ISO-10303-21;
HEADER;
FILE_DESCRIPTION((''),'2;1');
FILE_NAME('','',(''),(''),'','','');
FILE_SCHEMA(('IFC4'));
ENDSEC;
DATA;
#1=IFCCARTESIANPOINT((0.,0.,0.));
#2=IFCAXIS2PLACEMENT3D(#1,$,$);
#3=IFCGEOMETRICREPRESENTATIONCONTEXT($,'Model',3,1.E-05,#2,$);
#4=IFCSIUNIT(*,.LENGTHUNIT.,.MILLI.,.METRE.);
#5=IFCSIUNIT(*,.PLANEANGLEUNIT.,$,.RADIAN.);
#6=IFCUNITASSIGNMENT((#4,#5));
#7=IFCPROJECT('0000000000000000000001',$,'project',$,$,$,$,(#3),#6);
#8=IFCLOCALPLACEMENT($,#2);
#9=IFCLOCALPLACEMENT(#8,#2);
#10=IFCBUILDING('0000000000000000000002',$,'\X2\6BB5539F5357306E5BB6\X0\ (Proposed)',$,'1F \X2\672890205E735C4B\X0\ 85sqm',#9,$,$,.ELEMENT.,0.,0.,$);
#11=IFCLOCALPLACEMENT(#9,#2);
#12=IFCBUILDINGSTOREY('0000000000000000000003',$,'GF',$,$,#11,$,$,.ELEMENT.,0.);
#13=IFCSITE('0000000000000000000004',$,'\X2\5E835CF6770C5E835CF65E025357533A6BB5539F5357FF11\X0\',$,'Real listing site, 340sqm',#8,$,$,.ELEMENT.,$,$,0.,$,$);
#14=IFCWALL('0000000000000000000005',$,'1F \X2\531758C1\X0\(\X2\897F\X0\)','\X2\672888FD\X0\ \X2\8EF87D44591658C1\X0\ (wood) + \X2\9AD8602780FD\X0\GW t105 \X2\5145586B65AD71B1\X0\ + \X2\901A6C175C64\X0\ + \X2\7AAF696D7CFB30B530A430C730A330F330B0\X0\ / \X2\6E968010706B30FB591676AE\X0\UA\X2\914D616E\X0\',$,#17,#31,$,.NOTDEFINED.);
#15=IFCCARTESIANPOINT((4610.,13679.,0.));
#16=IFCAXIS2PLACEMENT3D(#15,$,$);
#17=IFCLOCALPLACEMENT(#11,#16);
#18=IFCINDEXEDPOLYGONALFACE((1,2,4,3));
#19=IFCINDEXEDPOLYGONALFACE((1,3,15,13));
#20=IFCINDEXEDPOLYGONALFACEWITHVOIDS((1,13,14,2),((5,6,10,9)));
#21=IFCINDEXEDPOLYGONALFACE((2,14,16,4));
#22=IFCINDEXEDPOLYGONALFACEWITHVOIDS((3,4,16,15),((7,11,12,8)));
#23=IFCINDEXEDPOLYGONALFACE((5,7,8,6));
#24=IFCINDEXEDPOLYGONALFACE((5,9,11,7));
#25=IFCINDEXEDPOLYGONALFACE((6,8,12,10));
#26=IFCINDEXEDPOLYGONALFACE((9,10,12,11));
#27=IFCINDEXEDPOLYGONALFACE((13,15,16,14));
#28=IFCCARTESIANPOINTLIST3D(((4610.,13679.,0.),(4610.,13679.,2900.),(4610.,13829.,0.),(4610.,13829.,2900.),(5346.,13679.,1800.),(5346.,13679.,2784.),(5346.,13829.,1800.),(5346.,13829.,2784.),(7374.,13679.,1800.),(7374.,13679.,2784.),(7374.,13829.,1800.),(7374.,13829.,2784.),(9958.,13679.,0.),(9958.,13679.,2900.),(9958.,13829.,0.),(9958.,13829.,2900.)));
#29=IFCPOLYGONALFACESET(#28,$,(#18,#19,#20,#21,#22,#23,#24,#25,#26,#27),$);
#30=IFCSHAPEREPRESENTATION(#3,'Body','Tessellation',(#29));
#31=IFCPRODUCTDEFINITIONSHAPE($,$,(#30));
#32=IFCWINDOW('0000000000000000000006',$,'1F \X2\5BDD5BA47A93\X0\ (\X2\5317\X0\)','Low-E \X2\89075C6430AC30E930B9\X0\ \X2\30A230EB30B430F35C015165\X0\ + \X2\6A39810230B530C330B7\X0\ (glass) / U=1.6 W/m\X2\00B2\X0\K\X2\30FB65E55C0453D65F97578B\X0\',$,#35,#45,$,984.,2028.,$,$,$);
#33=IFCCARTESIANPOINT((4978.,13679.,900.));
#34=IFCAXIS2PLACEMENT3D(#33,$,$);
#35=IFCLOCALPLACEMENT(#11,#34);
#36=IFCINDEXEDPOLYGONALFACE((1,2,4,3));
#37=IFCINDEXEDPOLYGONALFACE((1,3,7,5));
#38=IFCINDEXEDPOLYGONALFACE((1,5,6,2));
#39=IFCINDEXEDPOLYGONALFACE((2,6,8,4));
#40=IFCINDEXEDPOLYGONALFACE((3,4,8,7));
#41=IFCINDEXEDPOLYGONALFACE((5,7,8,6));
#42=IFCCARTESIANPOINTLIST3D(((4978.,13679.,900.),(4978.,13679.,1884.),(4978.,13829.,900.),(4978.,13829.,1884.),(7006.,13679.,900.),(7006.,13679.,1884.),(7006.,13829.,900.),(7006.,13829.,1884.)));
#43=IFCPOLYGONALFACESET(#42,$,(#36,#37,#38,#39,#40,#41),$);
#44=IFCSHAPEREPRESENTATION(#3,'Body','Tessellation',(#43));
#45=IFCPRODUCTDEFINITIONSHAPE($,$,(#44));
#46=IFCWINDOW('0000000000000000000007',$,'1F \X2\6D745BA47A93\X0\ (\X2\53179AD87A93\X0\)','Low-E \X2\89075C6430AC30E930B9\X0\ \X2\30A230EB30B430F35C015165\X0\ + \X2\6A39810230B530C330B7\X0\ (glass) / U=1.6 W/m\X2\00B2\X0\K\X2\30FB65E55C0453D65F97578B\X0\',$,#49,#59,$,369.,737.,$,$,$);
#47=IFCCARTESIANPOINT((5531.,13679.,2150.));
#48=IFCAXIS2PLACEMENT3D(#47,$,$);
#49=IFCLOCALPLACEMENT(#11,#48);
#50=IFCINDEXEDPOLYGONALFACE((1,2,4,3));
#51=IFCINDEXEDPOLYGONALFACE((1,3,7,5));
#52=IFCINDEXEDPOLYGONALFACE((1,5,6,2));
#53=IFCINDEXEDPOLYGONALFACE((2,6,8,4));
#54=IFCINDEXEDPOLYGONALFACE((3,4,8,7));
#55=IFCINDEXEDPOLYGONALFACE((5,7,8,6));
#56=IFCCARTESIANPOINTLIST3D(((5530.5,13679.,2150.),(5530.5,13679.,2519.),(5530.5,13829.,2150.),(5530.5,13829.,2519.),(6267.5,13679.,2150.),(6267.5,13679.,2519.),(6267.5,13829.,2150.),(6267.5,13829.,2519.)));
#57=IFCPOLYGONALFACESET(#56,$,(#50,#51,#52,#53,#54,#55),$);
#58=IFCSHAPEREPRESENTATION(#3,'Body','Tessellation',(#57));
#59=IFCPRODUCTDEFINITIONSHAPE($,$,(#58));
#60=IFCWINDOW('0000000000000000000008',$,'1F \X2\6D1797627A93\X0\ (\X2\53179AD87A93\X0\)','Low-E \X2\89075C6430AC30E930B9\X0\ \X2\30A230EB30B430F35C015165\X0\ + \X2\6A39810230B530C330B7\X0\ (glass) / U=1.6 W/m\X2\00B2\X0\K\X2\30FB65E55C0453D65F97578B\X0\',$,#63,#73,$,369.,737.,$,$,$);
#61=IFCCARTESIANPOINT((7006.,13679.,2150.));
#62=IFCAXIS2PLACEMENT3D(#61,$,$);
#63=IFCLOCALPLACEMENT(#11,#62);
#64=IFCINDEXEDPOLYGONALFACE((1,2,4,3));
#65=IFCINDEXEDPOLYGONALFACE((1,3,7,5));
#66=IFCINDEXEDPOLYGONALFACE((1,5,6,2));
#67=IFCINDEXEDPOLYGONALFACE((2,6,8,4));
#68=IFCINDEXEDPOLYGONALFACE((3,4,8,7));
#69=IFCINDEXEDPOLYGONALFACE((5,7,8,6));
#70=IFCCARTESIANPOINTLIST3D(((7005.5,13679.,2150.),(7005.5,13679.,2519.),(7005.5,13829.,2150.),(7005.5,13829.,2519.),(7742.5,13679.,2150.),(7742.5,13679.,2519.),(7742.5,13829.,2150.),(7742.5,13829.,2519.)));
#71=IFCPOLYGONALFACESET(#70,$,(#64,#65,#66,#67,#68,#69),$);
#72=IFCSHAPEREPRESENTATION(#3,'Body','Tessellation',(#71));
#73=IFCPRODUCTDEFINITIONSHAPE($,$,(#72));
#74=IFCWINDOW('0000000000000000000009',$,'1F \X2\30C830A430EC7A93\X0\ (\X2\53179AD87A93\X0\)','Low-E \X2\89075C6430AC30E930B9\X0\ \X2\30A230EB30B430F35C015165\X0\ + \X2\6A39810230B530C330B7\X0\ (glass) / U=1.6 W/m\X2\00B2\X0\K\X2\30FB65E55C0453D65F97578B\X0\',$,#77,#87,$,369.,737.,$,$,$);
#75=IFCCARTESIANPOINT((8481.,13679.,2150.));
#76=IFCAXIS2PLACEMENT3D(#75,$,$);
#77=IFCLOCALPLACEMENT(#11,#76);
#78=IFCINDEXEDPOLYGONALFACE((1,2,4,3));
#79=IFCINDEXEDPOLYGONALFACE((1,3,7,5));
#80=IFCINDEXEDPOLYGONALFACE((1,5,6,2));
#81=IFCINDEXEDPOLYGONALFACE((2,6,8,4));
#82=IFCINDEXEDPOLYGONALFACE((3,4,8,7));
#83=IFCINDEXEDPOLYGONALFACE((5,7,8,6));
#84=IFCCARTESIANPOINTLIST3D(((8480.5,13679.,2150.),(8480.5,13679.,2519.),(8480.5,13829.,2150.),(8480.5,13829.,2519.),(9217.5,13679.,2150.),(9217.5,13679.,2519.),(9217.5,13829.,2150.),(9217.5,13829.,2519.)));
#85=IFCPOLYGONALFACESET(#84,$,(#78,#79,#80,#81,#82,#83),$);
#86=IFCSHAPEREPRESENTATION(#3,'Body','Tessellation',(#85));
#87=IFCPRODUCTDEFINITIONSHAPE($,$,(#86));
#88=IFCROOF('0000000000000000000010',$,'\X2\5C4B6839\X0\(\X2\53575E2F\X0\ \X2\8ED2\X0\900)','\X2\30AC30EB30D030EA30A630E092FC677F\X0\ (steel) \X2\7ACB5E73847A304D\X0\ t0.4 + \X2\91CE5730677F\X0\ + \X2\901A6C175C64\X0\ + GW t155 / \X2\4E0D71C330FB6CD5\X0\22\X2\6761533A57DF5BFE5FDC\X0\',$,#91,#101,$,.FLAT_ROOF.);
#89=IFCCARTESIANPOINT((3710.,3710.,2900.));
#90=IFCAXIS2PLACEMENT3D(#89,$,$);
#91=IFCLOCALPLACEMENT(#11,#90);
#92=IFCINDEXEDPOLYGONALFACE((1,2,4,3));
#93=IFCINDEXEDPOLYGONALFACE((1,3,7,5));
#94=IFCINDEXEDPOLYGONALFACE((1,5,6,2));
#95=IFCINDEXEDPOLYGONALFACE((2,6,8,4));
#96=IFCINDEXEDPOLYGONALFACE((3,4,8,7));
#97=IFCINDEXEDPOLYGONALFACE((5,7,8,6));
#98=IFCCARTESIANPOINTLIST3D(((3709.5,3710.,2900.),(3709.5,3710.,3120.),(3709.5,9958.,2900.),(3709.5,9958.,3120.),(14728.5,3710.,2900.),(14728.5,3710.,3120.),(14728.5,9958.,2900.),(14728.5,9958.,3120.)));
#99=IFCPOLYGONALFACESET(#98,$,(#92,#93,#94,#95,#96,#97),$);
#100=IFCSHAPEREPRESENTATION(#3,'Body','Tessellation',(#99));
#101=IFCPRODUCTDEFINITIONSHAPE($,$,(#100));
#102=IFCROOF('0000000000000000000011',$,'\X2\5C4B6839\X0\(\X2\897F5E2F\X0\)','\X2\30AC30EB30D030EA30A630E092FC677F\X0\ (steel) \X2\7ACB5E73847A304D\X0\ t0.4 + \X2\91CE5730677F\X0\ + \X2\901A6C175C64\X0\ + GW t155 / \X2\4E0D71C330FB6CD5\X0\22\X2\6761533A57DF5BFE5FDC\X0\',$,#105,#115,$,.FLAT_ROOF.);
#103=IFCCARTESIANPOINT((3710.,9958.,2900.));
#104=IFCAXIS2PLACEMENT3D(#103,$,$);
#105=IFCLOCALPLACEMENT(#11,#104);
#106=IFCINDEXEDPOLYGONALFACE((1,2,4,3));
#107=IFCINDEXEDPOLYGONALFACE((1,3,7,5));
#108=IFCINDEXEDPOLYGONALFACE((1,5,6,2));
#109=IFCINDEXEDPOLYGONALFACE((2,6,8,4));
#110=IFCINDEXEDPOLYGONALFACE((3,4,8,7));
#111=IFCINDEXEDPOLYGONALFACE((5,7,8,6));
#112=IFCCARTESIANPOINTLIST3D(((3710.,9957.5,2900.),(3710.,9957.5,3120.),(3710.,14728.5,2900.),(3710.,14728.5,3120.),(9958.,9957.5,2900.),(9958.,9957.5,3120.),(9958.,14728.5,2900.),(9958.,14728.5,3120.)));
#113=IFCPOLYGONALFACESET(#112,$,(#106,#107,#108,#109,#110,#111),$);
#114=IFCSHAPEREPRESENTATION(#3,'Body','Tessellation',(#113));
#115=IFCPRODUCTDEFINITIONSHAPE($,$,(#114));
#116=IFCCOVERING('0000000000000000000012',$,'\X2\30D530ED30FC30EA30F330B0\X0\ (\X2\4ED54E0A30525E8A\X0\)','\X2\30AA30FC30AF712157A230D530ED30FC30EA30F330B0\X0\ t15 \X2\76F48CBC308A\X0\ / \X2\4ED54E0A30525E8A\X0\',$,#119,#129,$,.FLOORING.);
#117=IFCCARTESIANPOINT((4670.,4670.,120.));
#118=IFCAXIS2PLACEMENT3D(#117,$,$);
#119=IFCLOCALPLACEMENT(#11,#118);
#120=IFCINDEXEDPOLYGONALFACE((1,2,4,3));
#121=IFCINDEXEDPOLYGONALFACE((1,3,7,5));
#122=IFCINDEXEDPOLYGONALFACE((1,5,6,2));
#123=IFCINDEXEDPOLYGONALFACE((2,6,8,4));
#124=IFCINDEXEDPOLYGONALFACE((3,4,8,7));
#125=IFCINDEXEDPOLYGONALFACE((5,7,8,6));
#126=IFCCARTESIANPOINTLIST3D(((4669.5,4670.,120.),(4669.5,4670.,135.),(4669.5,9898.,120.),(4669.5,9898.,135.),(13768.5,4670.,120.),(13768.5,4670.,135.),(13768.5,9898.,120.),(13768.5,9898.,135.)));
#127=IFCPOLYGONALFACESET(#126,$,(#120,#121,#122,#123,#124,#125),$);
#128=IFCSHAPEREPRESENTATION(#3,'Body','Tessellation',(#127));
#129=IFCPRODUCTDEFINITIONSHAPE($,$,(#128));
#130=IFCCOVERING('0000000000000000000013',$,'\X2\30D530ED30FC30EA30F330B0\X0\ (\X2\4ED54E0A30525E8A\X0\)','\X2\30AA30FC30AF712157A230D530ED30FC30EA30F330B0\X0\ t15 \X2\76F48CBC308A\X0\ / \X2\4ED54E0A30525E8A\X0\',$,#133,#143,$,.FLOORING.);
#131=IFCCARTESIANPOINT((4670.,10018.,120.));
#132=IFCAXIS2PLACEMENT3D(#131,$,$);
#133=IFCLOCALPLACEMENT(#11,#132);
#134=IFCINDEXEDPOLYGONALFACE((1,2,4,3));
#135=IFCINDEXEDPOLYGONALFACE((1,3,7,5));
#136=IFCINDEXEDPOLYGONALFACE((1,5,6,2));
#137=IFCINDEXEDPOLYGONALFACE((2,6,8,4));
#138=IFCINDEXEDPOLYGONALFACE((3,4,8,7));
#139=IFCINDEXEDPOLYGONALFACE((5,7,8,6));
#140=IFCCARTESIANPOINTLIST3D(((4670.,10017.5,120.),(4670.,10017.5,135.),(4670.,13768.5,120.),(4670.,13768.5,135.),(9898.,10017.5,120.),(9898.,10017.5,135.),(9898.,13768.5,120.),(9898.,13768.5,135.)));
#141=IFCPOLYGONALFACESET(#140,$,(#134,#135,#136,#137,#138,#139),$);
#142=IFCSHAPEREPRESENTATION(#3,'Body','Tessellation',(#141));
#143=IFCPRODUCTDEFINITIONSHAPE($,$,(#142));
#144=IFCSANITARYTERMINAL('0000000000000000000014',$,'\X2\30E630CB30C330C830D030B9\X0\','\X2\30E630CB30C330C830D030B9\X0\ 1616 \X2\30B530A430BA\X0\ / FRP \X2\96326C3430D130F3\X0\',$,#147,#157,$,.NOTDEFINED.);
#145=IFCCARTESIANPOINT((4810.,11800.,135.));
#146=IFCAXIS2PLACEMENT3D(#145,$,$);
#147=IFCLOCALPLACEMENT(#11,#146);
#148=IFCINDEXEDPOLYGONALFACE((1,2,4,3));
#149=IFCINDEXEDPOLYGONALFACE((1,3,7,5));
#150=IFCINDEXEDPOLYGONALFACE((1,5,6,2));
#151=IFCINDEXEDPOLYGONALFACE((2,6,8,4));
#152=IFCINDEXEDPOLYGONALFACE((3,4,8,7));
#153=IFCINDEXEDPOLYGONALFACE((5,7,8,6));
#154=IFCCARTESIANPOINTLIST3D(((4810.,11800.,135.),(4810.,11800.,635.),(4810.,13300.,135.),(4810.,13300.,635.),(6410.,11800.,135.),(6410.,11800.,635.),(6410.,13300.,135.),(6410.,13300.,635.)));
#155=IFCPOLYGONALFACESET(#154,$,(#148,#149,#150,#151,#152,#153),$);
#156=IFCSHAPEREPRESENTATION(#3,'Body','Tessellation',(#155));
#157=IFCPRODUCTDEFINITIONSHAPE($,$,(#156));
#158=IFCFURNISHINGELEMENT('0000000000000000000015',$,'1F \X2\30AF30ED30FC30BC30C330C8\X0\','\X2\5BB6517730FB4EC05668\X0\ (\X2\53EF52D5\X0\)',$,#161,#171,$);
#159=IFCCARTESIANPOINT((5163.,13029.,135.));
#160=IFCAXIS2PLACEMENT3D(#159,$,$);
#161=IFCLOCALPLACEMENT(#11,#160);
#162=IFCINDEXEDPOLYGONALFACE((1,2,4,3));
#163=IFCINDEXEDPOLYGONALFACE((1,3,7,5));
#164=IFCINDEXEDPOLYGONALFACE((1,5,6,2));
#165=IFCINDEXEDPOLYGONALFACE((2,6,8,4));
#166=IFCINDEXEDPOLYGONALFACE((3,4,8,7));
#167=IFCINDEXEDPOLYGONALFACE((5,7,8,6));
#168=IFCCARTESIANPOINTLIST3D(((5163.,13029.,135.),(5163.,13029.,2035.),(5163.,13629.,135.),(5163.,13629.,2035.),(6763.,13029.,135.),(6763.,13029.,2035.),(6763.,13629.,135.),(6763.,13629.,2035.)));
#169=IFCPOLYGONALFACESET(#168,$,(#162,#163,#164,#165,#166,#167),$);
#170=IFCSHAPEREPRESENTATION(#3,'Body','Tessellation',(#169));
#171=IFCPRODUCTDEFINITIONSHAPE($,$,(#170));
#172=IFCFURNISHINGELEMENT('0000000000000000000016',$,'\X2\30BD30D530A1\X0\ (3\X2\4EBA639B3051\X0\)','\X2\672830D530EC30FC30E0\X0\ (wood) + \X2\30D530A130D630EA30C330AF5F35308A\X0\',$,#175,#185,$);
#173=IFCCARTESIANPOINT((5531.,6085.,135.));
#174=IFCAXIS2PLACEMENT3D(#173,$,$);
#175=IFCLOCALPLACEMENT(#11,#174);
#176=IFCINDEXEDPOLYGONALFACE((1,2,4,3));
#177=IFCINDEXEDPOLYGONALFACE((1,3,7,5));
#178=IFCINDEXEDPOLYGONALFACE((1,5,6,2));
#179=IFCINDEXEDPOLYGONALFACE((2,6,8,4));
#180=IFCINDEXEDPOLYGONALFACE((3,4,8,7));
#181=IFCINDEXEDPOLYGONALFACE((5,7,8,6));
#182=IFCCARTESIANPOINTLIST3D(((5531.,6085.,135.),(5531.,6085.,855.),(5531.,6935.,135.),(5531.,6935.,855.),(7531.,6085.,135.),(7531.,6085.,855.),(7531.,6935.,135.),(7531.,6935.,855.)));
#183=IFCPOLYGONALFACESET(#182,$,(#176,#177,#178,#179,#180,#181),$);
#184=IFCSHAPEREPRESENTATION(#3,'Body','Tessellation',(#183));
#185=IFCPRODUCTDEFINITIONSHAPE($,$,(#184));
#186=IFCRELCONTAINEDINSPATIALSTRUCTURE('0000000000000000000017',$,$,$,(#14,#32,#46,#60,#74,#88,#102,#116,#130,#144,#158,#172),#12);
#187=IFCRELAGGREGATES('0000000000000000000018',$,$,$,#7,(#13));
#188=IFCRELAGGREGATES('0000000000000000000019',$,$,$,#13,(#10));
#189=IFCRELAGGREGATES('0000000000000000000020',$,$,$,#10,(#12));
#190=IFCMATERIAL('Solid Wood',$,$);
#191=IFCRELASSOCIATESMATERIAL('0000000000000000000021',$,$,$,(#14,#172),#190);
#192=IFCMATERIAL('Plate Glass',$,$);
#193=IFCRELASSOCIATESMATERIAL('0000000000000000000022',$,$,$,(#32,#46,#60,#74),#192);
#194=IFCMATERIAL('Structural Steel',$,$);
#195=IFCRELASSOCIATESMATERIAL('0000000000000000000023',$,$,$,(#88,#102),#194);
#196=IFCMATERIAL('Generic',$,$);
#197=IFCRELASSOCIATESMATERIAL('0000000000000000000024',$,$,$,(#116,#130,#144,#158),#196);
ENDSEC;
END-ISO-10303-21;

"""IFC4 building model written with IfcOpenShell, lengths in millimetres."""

from ifc_helpers import new_model, si_unit, frame, frame_2d, origin, place, context, project, spatial, rectangle, extrude, material, element, fill, save


model = new_model("IFC4")

# Units and contexts
model_context = context("Model", 3, precision=1e-05, world=origin())
ifc_project = project(units=[si_unit("LENGTHUNIT", "METRE", prefix="MILLI"), si_unit("PLANEANGLEUNIT", "RADIAN")], contexts=[model_context])

# Site, building, storey
site_placement = place(None, origin())
site = spatial("IfcSite", under=ifc_project, at=site_placement, Name="広島県広島市南区段原南１", ObjectType="Real listing site, 340sqm", CompositionType="ELEMENT", RefElevation=0.0)
building_placement = place(site_placement, origin())
building = spatial("IfcBuilding", under=site, at=building_placement, Name="段原南の家 (Proposed)", ObjectType="1F 木造平屋 85sqm", CompositionType="ELEMENT", ElevationOfRefHeight=0.0, ElevationOfTerrain=0.0)
storey_placement = place(building_placement, origin())
storey = spatial("IfcBuildingStorey", under=building, at=storey_placement, Name="GF", CompositionType="ELEMENT", Elevation=0.0)

# Shared definitions
ifc_material_1 = material(Name="Solid Wood")

# Shared definitions
ifc_material_2 = material(Name="Plate Glass")

# Wall, openings, windows
wall_1_placement = place(storey_placement, frame((4610.0, 13679.0, 0.0)))
wall_1 = element("IfcWall", 1, at=wall_1_placement, inside=storey, material=ifc_material_1, Name="1F 北壁(西)", Description="木製 軸組外壁 (wood) + 高性能GW t105 充填断熱 + 通気層 + 窯業系サイディング / 準耐火・外皮UA配慮", PredefinedType="NOTDEFINED", context=model_context, shape_type="SweptSolid", body=[
    extrude(rectangle(XDim=5348.0, YDim=150.0, at=frame_2d((2674.0, 75.0))), frame((4610.0, 13679.0, 0.0)), (0.0, 0.0, 1.0), 2900.0),
])
opening_1_placement = place(storey_placement, frame((4978.0, 13679.0, 900.0)))
opening_1 = element("IfcOpeningElement", 2, at=opening_1_placement, cuts=wall_1, PredefinedType="NOTDEFINED", context=model_context, shape_type="SweptSolid", body=[
    extrude(rectangle(XDim=2028.0, YDim=150.0, at=frame_2d((1014.0, 75.0))), frame((4978.0, 13679.0, 900.0)), (0.0, 0.0, 1.0), 984.0),
])
opening_2_placement = place(storey_placement, frame((5531.0, 13679.0, 2150.0)))
opening_2 = element("IfcOpeningElement", 3, at=opening_2_placement, cuts=wall_1, PredefinedType="NOTDEFINED", context=model_context, shape_type="SweptSolid", body=[
    extrude(rectangle(XDim=737.0, YDim=150.0, at=frame_2d((368.0, 75.0))), frame((5531.0, 13679.0, 2150.0)), (0.0, 0.0, 1.0), 369.0),
])
opening_3_placement = place(storey_placement, frame((7006.0, 13679.0, 2150.0)))
opening_3 = element("IfcOpeningElement", 4, at=opening_3_placement, cuts=wall_1, PredefinedType="NOTDEFINED", context=model_context, shape_type="SweptSolid", body=[
    extrude(rectangle(XDim=737.0, YDim=150.0, at=frame_2d((368.0, 75.0))), frame((7006.0, 13679.0, 2150.0)), (0.0, 0.0, 1.0), 369.0),
])
opening_4_placement = place(storey_placement, frame((8481.0, 13679.0, 2150.0)))
opening_4 = element("IfcOpeningElement", 5, at=opening_4_placement, cuts=wall_1, PredefinedType="NOTDEFINED", context=model_context, shape_type="SweptSolid", body=[
    extrude(rectangle(XDim=737.0, YDim=150.0, at=frame_2d((368.0, 75.0))), frame((8481.0, 13679.0, 2150.0)), (0.0, 0.0, 1.0), 369.0),
])
window_1_placement = place(storey_placement, frame((4978.0, 13679.0, 900.0)))
window_1 = element("IfcWindow", 6, at=window_1_placement, inside=storey, material=ifc_material_2, Name="1F 寝室窓 (北)", Description="Low-E 複層ガラス アルゴン封入 + 樹脂サッシ (glass) / U=1.6 W/m²K・日射取得型", OverallHeight=984.0, OverallWidth=2028.0, context=model_context, shape_type="SweptSolid", body=[
    extrude(rectangle(XDim=2028.0, YDim=150.0, at=frame_2d((1014.0, 75.0))), frame((4978.0, 13679.0, 900.0)), (0.0, 0.0, 1.0), 984.0),
])
fill(opening_1, window_1)
window_2_placement = place(storey_placement, frame((5531.0, 13679.0, 2150.0)))
window_2 = element("IfcWindow", 7, at=window_2_placement, inside=storey, material=ifc_material_2, Name="1F 浴室窓 (北高窓)", Description="Low-E 複層ガラス アルゴン封入 + 樹脂サッシ (glass) / U=1.6 W/m²K・日射取得型", OverallHeight=369.0, OverallWidth=737.0, context=model_context, shape_type="SweptSolid", body=[
    extrude(rectangle(XDim=737.0, YDim=150.0, at=frame_2d((368.0, 75.0))), frame((5531.0, 13679.0, 2150.0)), (0.0, 0.0, 1.0), 369.0),
])
fill(opening_2, window_2)
window_3_placement = place(storey_placement, frame((7006.0, 13679.0, 2150.0)))
window_3 = element("IfcWindow", 8, at=window_3_placement, inside=storey, material=ifc_material_2, Name="1F 洗面窓 (北高窓)", Description="Low-E 複層ガラス アルゴン封入 + 樹脂サッシ (glass) / U=1.6 W/m²K・日射取得型", OverallHeight=369.0, OverallWidth=737.0, context=model_context, shape_type="SweptSolid", body=[
    extrude(rectangle(XDim=737.0, YDim=150.0, at=frame_2d((368.0, 75.0))), frame((7006.0, 13679.0, 2150.0)), (0.0, 0.0, 1.0), 369.0),
])
fill(opening_3, window_3)
window_4_placement = place(storey_placement, frame((8481.0, 13679.0, 2150.0)))
window_4 = element("IfcWindow", 9, at=window_4_placement, inside=storey, material=ifc_material_2, Name="1F トイレ窓 (北高窓)", Description="Low-E 複層ガラス アルゴン封入 + 樹脂サッシ (glass) / U=1.6 W/m²K・日射取得型", OverallHeight=369.0, OverallWidth=737.0, context=model_context, shape_type="SweptSolid", body=[
    extrude(rectangle(XDim=737.0, YDim=150.0, at=frame_2d((368.0, 75.0))), frame((8481.0, 13679.0, 2150.0)), (0.0, 0.0, 1.0), 369.0),
])
fill(opening_4, window_4)

# Roofs
ifc_material_3 = material(Name="Structural Steel")
roof_1_placement = place(storey_placement, frame((3710.0, 3710.0, 2900.0)))
element("IfcRoof", 10, at=roof_1_placement, inside=storey, material=ifc_material_3, Name="屋根(南帯 軒900)", Description="ガルバリウム鋼板 (steel) 立平葺き t0.4 + 野地板 + 通気層 + GW t155 / 不燃・法22条区域対応", PredefinedType="FLAT_ROOF", context=model_context, shape_type="SweptSolid", body=[
    extrude(rectangle(XDim=11019.0, YDim=6248.0, at=frame_2d((5509.0, 3124.0))), frame((3710.0, 3710.0, 2900.0)), (0.0, 0.0, 1.0), 220.0),
])
roof_2_placement = place(storey_placement, frame((3710.0, 9958.0, 2900.0)))
element("IfcRoof", 11, at=roof_2_placement, inside=storey, material=ifc_material_3, Name="屋根(西帯)", Description="ガルバリウム鋼板 (steel) 立平葺き t0.4 + 野地板 + 通気層 + GW t155 / 不燃・法22条区域対応", PredefinedType="FLAT_ROOF", context=model_context, shape_type="SweptSolid", body=[
    extrude(rectangle(XDim=6248.0, YDim=4771.0, at=frame_2d((3124.0, 2385.0))), frame((3710.0, 9958.0, 2900.0)), (0.0, 0.0, 1.0), 220.0),
])

# Coverings
ifc_material_4 = material(Name="Generic")
covering_1_placement = place(storey_placement, frame((4670.0, 4670.0, 120.0)))
element("IfcCovering", 12, at=covering_1_placement, inside=storey, material=ifc_material_4, Name="フローリング (仕上げ床)", Description="オーク無垢フローリング t15 直貼り / 仕上げ床", PredefinedType="FLOORING", context=model_context, shape_type="SweptSolid", body=[
    extrude(rectangle(XDim=9099.0, YDim=5228.0, at=frame_2d((4549.0, 2614.0))), frame((4670.0, 4670.0, 120.0)), (0.0, 0.0, 1.0), 15.0),
])
covering_2_placement = place(storey_placement, frame((4670.0, 10018.0, 120.0)))
element("IfcCovering", 13, at=covering_2_placement, inside=storey, material=ifc_material_4, Name="フローリング (仕上げ床)", Description="オーク無垢フローリング t15 直貼り / 仕上げ床", PredefinedType="FLOORING", context=model_context, shape_type="SweptSolid", body=[
    extrude(rectangle(XDim=5228.0, YDim=3751.0, at=frame_2d((2614.0, 1875.0))), frame((4670.0, 10018.0, 120.0)), (0.0, 0.0, 1.0), 15.0),
])

# Sanitary terminal
sanitary_terminal_placement = place(storey_placement, frame((4810.0, 11800.0, 135.0)))
element("IfcSanitaryTerminal", 14, at=sanitary_terminal_placement, inside=storey, material=ifc_material_4, Name="ユニットバス", Description="ユニットバス 1616 サイズ / FRP 防水パン", PredefinedType="NOTDEFINED", context=model_context, shape_type="SweptSolid", body=[
    extrude(rectangle(XDim=1600.0, YDim=1500.0, at=frame_2d((800.0, 750.0))), frame((4810.0, 11800.0, 135.0)), (0.0, 0.0, 1.0), 500.0),
])

# Furnishing elements
furnishing_1_placement = place(storey_placement, frame((5163.0, 13029.0, 135.0)))
element("IfcFurnishingElement", 15, at=furnishing_1_placement, inside=storey, material=ifc_material_4, Name="1F クローゼット", Description="家具・什器 (可動)", context=model_context, shape_type="SweptSolid", body=[
    extrude(rectangle(XDim=1600.0, YDim=600.0, at=frame_2d((800.0, 300.0))), frame((5163.0, 13029.0, 135.0)), (0.0, 0.0, 1.0), 1900.0),
])
furnishing_2_placement = place(storey_placement, frame((5531.0, 6085.0, 135.0)))
element("IfcFurnishingElement", 16, at=furnishing_2_placement, inside=storey, material=ifc_material_1, Name="ソファ (3人掛け)", Description="木フレーム (wood) + ファブリック張り", context=model_context, shape_type="SweptSolid", body=[
    extrude(rectangle(XDim=2000.0, YDim=850.0, at=frame_2d((1000.0, 425.0))), frame((5531.0, 6085.0, 135.0)), (0.0, 0.0, 1.0), 720.0),
])

save(model, "model.ifc")
